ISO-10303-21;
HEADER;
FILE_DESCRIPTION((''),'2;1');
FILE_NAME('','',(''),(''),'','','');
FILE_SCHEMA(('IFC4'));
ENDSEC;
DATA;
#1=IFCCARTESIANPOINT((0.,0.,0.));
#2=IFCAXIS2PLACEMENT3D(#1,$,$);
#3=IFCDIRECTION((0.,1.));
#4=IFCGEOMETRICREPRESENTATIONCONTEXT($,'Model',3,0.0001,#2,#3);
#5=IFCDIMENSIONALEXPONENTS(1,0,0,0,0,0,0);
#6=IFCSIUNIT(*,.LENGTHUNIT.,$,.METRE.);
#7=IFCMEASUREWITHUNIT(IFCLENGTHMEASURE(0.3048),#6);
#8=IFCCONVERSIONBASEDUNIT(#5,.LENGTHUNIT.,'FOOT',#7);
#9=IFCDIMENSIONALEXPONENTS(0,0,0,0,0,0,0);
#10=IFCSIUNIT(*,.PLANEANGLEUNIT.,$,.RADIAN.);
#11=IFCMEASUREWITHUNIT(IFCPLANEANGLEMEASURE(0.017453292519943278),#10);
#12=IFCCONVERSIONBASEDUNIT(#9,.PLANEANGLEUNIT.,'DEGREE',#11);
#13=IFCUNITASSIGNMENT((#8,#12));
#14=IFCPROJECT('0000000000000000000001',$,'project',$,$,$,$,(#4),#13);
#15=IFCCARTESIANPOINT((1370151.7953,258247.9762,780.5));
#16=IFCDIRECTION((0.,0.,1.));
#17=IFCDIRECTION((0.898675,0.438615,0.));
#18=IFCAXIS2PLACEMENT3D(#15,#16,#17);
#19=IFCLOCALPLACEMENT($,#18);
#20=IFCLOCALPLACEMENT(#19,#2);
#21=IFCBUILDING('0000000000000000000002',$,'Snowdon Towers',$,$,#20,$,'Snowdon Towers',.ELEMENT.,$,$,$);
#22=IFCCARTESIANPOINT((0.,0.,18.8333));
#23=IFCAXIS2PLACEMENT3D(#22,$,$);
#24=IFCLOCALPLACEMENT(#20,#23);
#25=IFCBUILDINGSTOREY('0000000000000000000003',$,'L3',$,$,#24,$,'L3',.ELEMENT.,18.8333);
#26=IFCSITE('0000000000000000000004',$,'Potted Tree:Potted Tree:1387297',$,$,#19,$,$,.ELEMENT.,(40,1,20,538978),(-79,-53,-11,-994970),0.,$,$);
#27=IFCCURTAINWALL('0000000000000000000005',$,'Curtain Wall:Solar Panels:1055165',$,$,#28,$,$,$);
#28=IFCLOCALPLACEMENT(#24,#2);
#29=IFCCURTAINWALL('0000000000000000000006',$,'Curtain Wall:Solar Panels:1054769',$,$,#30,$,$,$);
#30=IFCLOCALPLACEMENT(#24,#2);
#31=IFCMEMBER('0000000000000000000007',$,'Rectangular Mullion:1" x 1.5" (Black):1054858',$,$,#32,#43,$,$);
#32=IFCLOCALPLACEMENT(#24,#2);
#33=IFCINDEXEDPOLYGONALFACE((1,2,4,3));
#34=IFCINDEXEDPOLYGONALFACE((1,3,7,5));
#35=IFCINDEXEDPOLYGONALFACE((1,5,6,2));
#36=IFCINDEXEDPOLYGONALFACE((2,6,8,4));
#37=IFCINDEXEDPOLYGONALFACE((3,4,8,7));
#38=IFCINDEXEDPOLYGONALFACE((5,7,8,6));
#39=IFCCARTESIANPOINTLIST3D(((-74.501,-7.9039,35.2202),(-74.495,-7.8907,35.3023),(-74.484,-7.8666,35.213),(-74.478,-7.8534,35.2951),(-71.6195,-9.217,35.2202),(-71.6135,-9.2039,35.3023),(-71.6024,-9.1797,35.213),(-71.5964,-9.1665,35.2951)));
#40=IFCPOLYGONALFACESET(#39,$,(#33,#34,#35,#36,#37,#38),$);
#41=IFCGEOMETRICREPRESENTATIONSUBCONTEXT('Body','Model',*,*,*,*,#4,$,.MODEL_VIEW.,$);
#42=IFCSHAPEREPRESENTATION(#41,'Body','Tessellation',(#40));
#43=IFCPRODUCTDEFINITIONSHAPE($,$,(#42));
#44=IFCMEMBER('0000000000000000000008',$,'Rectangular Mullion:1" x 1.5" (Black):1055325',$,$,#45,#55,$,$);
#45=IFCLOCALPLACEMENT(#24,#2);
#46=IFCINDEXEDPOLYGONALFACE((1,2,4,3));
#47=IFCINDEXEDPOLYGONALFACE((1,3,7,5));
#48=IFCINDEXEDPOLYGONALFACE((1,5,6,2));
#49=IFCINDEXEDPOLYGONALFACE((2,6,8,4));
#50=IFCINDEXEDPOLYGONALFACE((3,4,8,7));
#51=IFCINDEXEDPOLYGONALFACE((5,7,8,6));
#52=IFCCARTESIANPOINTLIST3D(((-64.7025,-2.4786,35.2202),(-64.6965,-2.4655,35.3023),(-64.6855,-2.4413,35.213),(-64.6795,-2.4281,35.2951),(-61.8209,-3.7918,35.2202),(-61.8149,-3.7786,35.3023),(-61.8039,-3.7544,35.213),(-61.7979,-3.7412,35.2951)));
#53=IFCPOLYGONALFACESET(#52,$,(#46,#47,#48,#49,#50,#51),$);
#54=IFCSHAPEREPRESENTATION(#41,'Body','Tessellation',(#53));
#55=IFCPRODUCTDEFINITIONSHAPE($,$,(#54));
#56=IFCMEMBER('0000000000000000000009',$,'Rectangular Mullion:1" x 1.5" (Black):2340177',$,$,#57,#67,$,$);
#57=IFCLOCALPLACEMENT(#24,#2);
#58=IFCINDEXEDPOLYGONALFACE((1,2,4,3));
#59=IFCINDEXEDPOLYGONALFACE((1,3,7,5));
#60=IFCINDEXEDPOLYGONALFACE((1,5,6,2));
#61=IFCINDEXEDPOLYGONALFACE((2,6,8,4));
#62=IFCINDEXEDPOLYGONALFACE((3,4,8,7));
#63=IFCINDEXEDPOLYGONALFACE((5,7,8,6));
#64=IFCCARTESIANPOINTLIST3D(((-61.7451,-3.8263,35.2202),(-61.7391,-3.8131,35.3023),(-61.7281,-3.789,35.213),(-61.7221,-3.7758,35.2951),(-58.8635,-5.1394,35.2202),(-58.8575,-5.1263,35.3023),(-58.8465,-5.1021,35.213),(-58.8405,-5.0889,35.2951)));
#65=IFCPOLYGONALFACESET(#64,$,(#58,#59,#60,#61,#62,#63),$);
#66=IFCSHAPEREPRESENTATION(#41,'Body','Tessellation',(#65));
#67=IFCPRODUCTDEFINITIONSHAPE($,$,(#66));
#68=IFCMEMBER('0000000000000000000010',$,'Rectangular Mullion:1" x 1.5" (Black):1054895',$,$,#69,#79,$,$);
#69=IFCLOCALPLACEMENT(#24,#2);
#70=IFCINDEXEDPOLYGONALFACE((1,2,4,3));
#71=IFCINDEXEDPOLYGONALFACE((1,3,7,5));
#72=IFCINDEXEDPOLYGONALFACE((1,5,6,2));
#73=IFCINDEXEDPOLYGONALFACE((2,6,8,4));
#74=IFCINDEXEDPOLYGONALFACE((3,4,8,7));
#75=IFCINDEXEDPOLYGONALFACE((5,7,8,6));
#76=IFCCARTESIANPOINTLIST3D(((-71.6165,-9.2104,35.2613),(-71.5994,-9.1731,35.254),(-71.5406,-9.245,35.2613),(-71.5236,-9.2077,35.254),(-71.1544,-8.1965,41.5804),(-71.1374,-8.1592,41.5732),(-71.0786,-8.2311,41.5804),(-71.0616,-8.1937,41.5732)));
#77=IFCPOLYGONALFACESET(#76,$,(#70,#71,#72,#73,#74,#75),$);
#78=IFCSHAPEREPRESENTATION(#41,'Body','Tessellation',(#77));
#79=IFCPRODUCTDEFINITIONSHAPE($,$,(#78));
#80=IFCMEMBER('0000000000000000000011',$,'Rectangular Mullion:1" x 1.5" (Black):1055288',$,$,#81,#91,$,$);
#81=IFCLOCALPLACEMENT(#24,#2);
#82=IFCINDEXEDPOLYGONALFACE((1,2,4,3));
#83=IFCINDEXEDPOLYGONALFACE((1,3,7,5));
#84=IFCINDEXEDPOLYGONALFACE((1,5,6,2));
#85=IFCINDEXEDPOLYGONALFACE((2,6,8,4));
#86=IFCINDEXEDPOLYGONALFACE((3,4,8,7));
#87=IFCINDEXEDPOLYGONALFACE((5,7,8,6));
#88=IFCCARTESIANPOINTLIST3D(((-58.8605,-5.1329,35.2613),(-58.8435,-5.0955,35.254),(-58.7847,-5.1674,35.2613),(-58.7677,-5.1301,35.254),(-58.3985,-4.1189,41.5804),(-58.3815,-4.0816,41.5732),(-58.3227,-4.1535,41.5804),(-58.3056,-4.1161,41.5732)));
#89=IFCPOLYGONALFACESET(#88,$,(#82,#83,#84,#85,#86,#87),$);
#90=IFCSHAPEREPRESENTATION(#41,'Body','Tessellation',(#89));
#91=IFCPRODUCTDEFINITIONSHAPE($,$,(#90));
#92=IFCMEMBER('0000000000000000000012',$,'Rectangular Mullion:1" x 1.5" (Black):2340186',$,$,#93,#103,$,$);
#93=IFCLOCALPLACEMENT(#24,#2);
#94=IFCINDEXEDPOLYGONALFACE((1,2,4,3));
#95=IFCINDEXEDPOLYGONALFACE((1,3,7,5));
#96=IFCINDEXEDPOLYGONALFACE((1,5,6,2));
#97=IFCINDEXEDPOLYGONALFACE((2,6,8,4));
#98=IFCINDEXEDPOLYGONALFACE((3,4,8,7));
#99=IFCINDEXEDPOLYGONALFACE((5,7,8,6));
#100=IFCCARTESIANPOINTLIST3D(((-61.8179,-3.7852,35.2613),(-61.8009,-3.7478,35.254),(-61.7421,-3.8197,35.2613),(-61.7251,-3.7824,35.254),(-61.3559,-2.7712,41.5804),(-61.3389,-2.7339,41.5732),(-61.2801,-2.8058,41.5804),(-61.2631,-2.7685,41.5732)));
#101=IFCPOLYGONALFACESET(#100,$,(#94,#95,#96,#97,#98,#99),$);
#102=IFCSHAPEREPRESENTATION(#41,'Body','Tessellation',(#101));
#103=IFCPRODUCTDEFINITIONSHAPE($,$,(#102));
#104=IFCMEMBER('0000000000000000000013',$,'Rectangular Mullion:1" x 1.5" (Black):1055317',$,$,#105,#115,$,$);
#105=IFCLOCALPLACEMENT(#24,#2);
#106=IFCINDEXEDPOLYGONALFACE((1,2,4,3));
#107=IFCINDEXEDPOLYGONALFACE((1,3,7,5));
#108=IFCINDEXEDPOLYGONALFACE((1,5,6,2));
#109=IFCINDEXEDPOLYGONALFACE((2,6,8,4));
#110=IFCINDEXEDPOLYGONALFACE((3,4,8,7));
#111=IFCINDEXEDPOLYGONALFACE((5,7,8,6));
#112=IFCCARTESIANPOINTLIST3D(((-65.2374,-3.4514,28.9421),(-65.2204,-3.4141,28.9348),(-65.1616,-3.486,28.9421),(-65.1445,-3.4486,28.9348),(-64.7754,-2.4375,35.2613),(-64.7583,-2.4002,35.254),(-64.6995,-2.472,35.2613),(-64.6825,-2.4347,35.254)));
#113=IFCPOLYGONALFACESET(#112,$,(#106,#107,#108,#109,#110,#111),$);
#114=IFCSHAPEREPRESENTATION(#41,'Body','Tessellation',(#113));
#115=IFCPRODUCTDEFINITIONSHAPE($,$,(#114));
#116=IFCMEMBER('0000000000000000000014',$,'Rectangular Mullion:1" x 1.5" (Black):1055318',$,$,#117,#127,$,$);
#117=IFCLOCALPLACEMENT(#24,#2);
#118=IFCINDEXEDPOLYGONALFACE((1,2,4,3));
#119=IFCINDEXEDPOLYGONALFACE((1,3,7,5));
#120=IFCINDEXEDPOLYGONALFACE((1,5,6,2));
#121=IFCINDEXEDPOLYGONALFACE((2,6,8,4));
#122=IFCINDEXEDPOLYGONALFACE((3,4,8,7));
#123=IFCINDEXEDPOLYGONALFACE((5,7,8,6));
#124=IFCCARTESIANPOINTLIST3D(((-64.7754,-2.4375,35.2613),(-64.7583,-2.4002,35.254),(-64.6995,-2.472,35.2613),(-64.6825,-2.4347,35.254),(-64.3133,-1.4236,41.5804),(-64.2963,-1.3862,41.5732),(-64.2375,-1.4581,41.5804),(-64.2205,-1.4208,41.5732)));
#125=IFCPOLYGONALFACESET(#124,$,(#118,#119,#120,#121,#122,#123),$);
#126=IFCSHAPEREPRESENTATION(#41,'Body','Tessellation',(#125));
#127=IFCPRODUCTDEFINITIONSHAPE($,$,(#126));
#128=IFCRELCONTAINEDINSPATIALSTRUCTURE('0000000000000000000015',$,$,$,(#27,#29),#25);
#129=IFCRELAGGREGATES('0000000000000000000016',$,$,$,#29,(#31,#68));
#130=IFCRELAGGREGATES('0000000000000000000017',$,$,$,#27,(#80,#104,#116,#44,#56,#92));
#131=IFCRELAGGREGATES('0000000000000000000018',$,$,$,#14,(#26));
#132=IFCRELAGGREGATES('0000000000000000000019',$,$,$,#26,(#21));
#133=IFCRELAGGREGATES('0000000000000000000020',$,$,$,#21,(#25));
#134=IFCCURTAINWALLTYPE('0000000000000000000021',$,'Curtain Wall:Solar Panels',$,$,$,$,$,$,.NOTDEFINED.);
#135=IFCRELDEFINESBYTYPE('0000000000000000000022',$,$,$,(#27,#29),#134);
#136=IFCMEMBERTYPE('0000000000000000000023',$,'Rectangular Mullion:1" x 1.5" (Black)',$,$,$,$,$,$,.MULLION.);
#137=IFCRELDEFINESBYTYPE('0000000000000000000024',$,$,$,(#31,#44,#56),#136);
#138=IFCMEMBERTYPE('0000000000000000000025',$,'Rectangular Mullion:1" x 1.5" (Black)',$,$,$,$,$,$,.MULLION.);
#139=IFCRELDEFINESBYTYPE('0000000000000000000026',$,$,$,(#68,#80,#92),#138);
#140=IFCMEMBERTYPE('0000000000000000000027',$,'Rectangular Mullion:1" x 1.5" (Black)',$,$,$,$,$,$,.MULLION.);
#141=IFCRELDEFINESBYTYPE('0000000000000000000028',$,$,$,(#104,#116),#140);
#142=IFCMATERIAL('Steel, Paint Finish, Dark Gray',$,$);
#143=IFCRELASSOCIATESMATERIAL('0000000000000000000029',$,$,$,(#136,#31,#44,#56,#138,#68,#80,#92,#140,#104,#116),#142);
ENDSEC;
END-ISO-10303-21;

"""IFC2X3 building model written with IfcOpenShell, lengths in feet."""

from ifc_helpers import new_model, entity, si_unit, converted_unit, direction, frame, frame_2d, origin, origin_2d_with_axis, place, context, subcontext, project, spatial, rectangle, extrude, source, transform, mapped, material, type_object, type_shapes, element, aggregate, save


model = new_model("IFC2X3")

# Units and contexts
model_context = context("Model", 3, precision=0.0001, world=origin(), true_north=direction((0.0, 1.0)))
body_context = subcontext(model_context, "Body", "Model", "MODEL_VIEW")
ifc_project = project(units=[converted_unit("LENGTHUNIT", "FOOT", entity("IfcLengthMeasure", 0.3048), si_unit("LENGTHUNIT", "METRE"), dimensions=[1, 0, 0, 0, 0, 0, 0]), converted_unit("PLANEANGLEUNIT", "DEGREE", entity("IfcPlaneAngleMeasure", 0.017453292519943278), si_unit("PLANEANGLEUNIT", "RADIAN"), dimensions=[0, 0, 0, 0, 0, 0, 0])], contexts=[model_context])

# Site, building, storey
site_placement = place(None, frame((1370151.7953, 258247.9762, 780.5), z_axis=(0.0, 0.0, 1.0), x_axis=(0.898675, 0.438615, 0.0)))
site = spatial("IfcSite", under=ifc_project, at=site_placement, Name="Potted Tree:Potted Tree:1387297", CompositionType="ELEMENT", RefLatitude=(40, 1, 20, 538978), RefLongitude=(-79, -53, -11, -994970), RefElevation=0.0)
building_placement = place(site_placement, origin())
building = spatial("IfcBuilding", under=site, at=building_placement, Name="Snowdon Towers", LongName="Snowdon Towers", CompositionType="ELEMENT")
storey_placement = place(building_placement, frame((0.0, 0.0, 18.8333)))
storey = spatial("IfcBuildingStorey", under=building, at=storey_placement, Name="L3", LongName="L3", CompositionType="ELEMENT", Elevation=18.8333)

# Curtain walls
curtain_wall_type_1 = type_object("IfcCurtainWallType", Name="Curtain Wall:Solar Panels", PredefinedType="NOTDEFINED")
curtain_wall_1_placement = place(storey_placement, frame((0.0, 0.0, -18.8333)))
curtain_wall_1 = element("IfcCurtainWall", 1, at=curtain_wall_1_placement, inside=storey, type_object=curtain_wall_type_1, Name="Curtain Wall:Solar Panels:1055165")
curtain_wall_2_placement = place(storey_placement, frame((0.0, 0.0, -18.8333)))
curtain_wall_2 = element("IfcCurtainWall", 2, at=curtain_wall_2_placement, inside=storey, type_object=curtain_wall_type_1, Name="Curtain Wall:Solar Panels:1054769")

# Members
ifc_material_1 = material(Name="Steel, Paint Finish, Dark Gray")
member_type_1 = type_object("IfcMemberType", Name="Rectangular Mullion:1\" x 1.5\" (Black)", PredefinedType="MULLION", material=ifc_material_1)
shared_shape_1 = source(origin(), body_context, "Body", "SweptSolid", [
    extrude(rectangle(XDim=0.0833, YDim=0.0417, at=origin_2d_with_axis()), frame((0.0, 0.0208, -3.1667), z_axis=(0.0, 0.0, 1.0), x_axis=(-1.0, 0.0, 0.0)), (0.0, 0.0, 1.0), 3.1667),
])
type_shapes(member_type_1, [shared_shape_1])
member_1_placement = place(curtain_wall_2_placement, frame((-71.5994, -9.1731, 54.0874), z_axis=(0.909972, -0.414671, 0.0), x_axis=(0.072007, 0.158015, 0.984808)))
member_1 = element("IfcMember", 3, at=member_1_placement, type_object=member_type_1, material=ifc_material_1, Name="Rectangular Mullion:1\" x 1.5\" (Black):1054858", context=body_context, shape_type="MappedRepresentation", body=[
    mapped(shared_shape_1, transform((0.0, 0.0, 0.0), scale=1.0)),
])
member_2_placement = place(curtain_wall_1_placement, frame((-61.8009, -3.7478, 54.0874), z_axis=(0.909972, -0.414671, 0.0), x_axis=(0.072007, 0.158015, 0.984808)))
member_2 = element("IfcMember", 4, at=member_2_placement, type_object=member_type_1, material=ifc_material_1, Name="Rectangular Mullion:1\" x 1.5\" (Black):1055325", context=body_context, shape_type="MappedRepresentation", body=[
    mapped(shared_shape_1, transform((0.0, 0.0, 0.0), scale=1.0)),
])
member_3_placement = place(curtain_wall_1_placement, frame((-58.8435, -5.0955, 54.0874), z_axis=(0.909972, -0.414671, 0.0), x_axis=(0.072007, 0.158015, 0.984808)))
member_3 = element("IfcMember", 5, at=member_3_placement, type_object=member_type_1, material=ifc_material_1, Name="Rectangular Mullion:1\" x 1.5\" (Black):2340177", context=body_context, shape_type="MappedRepresentation", body=[
    mapped(shared_shape_1, transform((0.0, 0.0, 0.0), scale=1.0)),
])
member_type_2 = type_object("IfcMemberType", Name="Rectangular Mullion:1\" x 1.5\" (Black)", PredefinedType="MULLION", material=ifc_material_1)
shared_shape_2 = source(origin(), body_context, "Body", "SweptSolid", [
    extrude(rectangle(XDim=0.0833, YDim=0.0417, at=origin_2d_with_axis()), frame((0.0, 0.0208, -6.4167), z_axis=(0.0, 0.0, 1.0), x_axis=(-1.0, 0.0, 0.0)), (0.0, 0.0, 1.0), 6.4167),
])
type_shapes(member_type_2, [shared_shape_2])
member_4_placement = place(curtain_wall_2_placement, frame((-71.5615, -9.1904, 54.0874), z_axis=(-0.072007, -0.158015, -0.984808), x_axis=(0.909972, -0.414671, 0.0)))
member_4 = element("IfcMember", 6, at=member_4_placement, type_object=member_type_2, material=ifc_material_1, Name="Rectangular Mullion:1\" x 1.5\" (Black):1054895", context=body_context, shape_type="MappedRepresentation", body=[
    mapped(shared_shape_2, transform((0.0, 0.0, 0.0), scale=1.0)),
])
member_5_placement = place(curtain_wall_1_placement, frame((-58.8056, -5.1128, 54.0874), z_axis=(-0.072007, -0.158015, -0.984808), x_axis=(0.909972, -0.414671, 0.0)))
member_5 = element("IfcMember", 7, at=member_5_placement, type_object=member_type_2, material=ifc_material_1, Name="Rectangular Mullion:1\" x 1.5\" (Black):1055288", context=body_context, shape_type="MappedRepresentation", body=[
    mapped(shared_shape_2, transform((0.0, 0.0, 0.0), scale=1.0)),
])
member_6_placement = place(curtain_wall_1_placement, frame((-61.763, -3.7651, 54.0874), z_axis=(-0.072007, -0.158015, -0.984808), x_axis=(0.909972, -0.414671, 0.0)))
member_6 = element("IfcMember", 8, at=member_6_placement, type_object=member_type_2, material=ifc_material_1, Name="Rectangular Mullion:1\" x 1.5\" (Black):2340186", context=body_context, shape_type="MappedRepresentation", body=[
    mapped(shared_shape_2, transform((0.0, 0.0, 0.0), scale=1.0)),
])
member_type_3 = type_object("IfcMemberType", Name="Rectangular Mullion:1\" x 1.5\" (Black)", PredefinedType="MULLION", material=ifc_material_1)
shared_shape_3 = source(origin(), body_context, "Body", "SweptSolid", [
    extrude(rectangle(XDim=0.0833, YDim=0.0417, at=frame_2d((0.0, 0.0), x_axis=(1.0, 0.0))), frame((-0.0417, 0.0208, -6.4167), z_axis=(0.0, 0.0, 1.0), x_axis=(-1.0, 0.0, 0.0)), (0.0, 0.0, 1.0), 6.4167),
])
type_shapes(member_type_3, [shared_shape_3])
member_7_placement = place(curtain_wall_1_placement, frame((-64.7583, -2.4002, 54.0874), z_axis=(0.072007, 0.158015, 0.984808), x_axis=(-0.909972, 0.414671, 0.0)))
member_7 = element("IfcMember", 9, at=member_7_placement, type_object=member_type_3, material=ifc_material_1, Name="Rectangular Mullion:1\" x 1.5\" (Black):1055317", context=body_context, shape_type="MappedRepresentation", body=[
    mapped(shared_shape_3, transform((0.0, 0.0, 0.0), scale=1.0)),
])
member_8_placement = place(curtain_wall_1_placement, frame((-64.2963, -1.3862, 60.4065), z_axis=(0.072007, 0.158015, 0.984808), x_axis=(-0.909972, 0.414671, 0.0)))
member_8 = element("IfcMember", 10, at=member_8_placement, type_object=member_type_3, material=ifc_material_1, Name="Rectangular Mullion:1\" x 1.5\" (Black):1055318", context=body_context, shape_type="MappedRepresentation", body=[
    mapped(shared_shape_3, transform((0.0, 0.0, 0.0), scale=1.0)),
])

aggregate(curtain_wall_2, [member_1, member_4])
aggregate(curtain_wall_1, [member_5, member_7, member_8, member_2, member_3, member_6])

save(model, "model.ifc")
